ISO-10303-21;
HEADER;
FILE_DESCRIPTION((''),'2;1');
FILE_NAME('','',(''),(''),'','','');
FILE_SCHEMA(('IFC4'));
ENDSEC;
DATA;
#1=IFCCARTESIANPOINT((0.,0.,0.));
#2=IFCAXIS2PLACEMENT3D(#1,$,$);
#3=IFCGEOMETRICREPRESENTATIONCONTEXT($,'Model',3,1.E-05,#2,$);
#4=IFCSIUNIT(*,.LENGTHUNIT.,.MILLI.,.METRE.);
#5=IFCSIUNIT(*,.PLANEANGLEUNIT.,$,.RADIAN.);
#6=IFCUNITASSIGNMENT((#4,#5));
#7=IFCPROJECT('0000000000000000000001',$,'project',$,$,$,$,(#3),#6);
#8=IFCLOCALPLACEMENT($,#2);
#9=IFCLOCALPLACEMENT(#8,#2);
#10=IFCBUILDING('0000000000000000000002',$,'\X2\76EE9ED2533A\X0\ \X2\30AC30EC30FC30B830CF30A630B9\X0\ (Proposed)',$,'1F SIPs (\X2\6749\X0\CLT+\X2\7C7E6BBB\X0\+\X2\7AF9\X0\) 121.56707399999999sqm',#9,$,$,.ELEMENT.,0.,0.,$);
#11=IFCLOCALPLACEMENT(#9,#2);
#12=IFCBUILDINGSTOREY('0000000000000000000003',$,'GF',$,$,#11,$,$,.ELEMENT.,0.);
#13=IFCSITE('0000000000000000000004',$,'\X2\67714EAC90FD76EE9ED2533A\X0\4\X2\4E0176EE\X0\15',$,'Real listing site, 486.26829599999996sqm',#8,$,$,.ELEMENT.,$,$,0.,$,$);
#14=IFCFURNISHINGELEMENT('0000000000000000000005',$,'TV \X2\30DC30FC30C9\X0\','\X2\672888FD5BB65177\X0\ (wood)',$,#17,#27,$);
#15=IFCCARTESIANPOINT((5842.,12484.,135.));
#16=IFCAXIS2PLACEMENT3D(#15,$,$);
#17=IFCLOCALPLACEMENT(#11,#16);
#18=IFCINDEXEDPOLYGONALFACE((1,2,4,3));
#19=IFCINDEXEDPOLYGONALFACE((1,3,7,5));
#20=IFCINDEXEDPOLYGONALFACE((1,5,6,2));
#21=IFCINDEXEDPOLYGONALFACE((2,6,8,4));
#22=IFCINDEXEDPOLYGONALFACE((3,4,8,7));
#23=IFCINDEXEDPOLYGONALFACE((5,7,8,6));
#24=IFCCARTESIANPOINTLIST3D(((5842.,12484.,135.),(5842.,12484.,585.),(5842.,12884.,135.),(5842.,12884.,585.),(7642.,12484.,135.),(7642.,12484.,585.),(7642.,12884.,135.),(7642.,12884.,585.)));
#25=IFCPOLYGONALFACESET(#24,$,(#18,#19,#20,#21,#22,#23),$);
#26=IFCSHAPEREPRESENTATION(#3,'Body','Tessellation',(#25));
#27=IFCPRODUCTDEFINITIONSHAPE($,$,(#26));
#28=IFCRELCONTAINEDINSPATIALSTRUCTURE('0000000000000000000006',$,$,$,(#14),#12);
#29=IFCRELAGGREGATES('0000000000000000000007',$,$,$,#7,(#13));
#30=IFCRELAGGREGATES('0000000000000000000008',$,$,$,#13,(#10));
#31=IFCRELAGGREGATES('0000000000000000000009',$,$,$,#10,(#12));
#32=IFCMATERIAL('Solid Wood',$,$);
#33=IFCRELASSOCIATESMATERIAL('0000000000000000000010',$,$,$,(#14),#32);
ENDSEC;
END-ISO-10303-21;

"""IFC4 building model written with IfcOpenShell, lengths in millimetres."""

from ifc_helpers import new_model, si_unit, frame, frame_2d, origin, place, context, project, spatial, rectangle, extrude, material, element, save


model = new_model("IFC4")

# Units and contexts
model_context = context("Model", 3, precision=1e-05, world=origin())
ifc_project = project(units=[si_unit("LENGTHUNIT", "METRE", prefix="MILLI"), si_unit("PLANEANGLEUNIT", "RADIAN")], contexts=[model_context])

# Site, building, storey
site_placement = place(None, origin())
site = spatial("IfcSite", under=ifc_project, at=site_placement, Name="東京都目黒区4丁目15", ObjectType="Real listing site, 486.26829599999996sqm", CompositionType="ELEMENT", RefElevation=0.0)
building_placement = place(site_placement, origin())
building = spatial("IfcBuilding", under=site, at=building_placement, Name="目黒区 ガレージハウス (Proposed)", ObjectType="1F SIPs (杉CLT+籾殻+竹) 121.56707399999999sqm", CompositionType="ELEMENT", ElevationOfRefHeight=0.0, ElevationOfTerrain=0.0)
storey_placement = place(building_placement, origin())
storey = spatial("IfcBuildingStorey", under=building, at=storey_placement, Name="GF", CompositionType="ELEMENT", Elevation=0.0)

# Shared definitions
ifc_material_1 = material(Name="Solid Wood")

# Furnishing element
furnishing_1_placement = place(storey_placement, frame((5842.0, 12484.0, 135.0)))
element("IfcFurnishingElement", 1, at=furnishing_1_placement, inside=storey, material=ifc_material_1, Name="TV ボード", Description="木製家具 (wood)", context=model_context, shape_type="SweptSolid", body=[
    extrude(rectangle(XDim=1800.0, YDim=400.0, at=frame_2d((900.0, 200.0))), frame((5842.0, 12484.0, 135.0)), (0.0, 0.0, 1.0), 450.0),
])

save(model, "model.ifc")
